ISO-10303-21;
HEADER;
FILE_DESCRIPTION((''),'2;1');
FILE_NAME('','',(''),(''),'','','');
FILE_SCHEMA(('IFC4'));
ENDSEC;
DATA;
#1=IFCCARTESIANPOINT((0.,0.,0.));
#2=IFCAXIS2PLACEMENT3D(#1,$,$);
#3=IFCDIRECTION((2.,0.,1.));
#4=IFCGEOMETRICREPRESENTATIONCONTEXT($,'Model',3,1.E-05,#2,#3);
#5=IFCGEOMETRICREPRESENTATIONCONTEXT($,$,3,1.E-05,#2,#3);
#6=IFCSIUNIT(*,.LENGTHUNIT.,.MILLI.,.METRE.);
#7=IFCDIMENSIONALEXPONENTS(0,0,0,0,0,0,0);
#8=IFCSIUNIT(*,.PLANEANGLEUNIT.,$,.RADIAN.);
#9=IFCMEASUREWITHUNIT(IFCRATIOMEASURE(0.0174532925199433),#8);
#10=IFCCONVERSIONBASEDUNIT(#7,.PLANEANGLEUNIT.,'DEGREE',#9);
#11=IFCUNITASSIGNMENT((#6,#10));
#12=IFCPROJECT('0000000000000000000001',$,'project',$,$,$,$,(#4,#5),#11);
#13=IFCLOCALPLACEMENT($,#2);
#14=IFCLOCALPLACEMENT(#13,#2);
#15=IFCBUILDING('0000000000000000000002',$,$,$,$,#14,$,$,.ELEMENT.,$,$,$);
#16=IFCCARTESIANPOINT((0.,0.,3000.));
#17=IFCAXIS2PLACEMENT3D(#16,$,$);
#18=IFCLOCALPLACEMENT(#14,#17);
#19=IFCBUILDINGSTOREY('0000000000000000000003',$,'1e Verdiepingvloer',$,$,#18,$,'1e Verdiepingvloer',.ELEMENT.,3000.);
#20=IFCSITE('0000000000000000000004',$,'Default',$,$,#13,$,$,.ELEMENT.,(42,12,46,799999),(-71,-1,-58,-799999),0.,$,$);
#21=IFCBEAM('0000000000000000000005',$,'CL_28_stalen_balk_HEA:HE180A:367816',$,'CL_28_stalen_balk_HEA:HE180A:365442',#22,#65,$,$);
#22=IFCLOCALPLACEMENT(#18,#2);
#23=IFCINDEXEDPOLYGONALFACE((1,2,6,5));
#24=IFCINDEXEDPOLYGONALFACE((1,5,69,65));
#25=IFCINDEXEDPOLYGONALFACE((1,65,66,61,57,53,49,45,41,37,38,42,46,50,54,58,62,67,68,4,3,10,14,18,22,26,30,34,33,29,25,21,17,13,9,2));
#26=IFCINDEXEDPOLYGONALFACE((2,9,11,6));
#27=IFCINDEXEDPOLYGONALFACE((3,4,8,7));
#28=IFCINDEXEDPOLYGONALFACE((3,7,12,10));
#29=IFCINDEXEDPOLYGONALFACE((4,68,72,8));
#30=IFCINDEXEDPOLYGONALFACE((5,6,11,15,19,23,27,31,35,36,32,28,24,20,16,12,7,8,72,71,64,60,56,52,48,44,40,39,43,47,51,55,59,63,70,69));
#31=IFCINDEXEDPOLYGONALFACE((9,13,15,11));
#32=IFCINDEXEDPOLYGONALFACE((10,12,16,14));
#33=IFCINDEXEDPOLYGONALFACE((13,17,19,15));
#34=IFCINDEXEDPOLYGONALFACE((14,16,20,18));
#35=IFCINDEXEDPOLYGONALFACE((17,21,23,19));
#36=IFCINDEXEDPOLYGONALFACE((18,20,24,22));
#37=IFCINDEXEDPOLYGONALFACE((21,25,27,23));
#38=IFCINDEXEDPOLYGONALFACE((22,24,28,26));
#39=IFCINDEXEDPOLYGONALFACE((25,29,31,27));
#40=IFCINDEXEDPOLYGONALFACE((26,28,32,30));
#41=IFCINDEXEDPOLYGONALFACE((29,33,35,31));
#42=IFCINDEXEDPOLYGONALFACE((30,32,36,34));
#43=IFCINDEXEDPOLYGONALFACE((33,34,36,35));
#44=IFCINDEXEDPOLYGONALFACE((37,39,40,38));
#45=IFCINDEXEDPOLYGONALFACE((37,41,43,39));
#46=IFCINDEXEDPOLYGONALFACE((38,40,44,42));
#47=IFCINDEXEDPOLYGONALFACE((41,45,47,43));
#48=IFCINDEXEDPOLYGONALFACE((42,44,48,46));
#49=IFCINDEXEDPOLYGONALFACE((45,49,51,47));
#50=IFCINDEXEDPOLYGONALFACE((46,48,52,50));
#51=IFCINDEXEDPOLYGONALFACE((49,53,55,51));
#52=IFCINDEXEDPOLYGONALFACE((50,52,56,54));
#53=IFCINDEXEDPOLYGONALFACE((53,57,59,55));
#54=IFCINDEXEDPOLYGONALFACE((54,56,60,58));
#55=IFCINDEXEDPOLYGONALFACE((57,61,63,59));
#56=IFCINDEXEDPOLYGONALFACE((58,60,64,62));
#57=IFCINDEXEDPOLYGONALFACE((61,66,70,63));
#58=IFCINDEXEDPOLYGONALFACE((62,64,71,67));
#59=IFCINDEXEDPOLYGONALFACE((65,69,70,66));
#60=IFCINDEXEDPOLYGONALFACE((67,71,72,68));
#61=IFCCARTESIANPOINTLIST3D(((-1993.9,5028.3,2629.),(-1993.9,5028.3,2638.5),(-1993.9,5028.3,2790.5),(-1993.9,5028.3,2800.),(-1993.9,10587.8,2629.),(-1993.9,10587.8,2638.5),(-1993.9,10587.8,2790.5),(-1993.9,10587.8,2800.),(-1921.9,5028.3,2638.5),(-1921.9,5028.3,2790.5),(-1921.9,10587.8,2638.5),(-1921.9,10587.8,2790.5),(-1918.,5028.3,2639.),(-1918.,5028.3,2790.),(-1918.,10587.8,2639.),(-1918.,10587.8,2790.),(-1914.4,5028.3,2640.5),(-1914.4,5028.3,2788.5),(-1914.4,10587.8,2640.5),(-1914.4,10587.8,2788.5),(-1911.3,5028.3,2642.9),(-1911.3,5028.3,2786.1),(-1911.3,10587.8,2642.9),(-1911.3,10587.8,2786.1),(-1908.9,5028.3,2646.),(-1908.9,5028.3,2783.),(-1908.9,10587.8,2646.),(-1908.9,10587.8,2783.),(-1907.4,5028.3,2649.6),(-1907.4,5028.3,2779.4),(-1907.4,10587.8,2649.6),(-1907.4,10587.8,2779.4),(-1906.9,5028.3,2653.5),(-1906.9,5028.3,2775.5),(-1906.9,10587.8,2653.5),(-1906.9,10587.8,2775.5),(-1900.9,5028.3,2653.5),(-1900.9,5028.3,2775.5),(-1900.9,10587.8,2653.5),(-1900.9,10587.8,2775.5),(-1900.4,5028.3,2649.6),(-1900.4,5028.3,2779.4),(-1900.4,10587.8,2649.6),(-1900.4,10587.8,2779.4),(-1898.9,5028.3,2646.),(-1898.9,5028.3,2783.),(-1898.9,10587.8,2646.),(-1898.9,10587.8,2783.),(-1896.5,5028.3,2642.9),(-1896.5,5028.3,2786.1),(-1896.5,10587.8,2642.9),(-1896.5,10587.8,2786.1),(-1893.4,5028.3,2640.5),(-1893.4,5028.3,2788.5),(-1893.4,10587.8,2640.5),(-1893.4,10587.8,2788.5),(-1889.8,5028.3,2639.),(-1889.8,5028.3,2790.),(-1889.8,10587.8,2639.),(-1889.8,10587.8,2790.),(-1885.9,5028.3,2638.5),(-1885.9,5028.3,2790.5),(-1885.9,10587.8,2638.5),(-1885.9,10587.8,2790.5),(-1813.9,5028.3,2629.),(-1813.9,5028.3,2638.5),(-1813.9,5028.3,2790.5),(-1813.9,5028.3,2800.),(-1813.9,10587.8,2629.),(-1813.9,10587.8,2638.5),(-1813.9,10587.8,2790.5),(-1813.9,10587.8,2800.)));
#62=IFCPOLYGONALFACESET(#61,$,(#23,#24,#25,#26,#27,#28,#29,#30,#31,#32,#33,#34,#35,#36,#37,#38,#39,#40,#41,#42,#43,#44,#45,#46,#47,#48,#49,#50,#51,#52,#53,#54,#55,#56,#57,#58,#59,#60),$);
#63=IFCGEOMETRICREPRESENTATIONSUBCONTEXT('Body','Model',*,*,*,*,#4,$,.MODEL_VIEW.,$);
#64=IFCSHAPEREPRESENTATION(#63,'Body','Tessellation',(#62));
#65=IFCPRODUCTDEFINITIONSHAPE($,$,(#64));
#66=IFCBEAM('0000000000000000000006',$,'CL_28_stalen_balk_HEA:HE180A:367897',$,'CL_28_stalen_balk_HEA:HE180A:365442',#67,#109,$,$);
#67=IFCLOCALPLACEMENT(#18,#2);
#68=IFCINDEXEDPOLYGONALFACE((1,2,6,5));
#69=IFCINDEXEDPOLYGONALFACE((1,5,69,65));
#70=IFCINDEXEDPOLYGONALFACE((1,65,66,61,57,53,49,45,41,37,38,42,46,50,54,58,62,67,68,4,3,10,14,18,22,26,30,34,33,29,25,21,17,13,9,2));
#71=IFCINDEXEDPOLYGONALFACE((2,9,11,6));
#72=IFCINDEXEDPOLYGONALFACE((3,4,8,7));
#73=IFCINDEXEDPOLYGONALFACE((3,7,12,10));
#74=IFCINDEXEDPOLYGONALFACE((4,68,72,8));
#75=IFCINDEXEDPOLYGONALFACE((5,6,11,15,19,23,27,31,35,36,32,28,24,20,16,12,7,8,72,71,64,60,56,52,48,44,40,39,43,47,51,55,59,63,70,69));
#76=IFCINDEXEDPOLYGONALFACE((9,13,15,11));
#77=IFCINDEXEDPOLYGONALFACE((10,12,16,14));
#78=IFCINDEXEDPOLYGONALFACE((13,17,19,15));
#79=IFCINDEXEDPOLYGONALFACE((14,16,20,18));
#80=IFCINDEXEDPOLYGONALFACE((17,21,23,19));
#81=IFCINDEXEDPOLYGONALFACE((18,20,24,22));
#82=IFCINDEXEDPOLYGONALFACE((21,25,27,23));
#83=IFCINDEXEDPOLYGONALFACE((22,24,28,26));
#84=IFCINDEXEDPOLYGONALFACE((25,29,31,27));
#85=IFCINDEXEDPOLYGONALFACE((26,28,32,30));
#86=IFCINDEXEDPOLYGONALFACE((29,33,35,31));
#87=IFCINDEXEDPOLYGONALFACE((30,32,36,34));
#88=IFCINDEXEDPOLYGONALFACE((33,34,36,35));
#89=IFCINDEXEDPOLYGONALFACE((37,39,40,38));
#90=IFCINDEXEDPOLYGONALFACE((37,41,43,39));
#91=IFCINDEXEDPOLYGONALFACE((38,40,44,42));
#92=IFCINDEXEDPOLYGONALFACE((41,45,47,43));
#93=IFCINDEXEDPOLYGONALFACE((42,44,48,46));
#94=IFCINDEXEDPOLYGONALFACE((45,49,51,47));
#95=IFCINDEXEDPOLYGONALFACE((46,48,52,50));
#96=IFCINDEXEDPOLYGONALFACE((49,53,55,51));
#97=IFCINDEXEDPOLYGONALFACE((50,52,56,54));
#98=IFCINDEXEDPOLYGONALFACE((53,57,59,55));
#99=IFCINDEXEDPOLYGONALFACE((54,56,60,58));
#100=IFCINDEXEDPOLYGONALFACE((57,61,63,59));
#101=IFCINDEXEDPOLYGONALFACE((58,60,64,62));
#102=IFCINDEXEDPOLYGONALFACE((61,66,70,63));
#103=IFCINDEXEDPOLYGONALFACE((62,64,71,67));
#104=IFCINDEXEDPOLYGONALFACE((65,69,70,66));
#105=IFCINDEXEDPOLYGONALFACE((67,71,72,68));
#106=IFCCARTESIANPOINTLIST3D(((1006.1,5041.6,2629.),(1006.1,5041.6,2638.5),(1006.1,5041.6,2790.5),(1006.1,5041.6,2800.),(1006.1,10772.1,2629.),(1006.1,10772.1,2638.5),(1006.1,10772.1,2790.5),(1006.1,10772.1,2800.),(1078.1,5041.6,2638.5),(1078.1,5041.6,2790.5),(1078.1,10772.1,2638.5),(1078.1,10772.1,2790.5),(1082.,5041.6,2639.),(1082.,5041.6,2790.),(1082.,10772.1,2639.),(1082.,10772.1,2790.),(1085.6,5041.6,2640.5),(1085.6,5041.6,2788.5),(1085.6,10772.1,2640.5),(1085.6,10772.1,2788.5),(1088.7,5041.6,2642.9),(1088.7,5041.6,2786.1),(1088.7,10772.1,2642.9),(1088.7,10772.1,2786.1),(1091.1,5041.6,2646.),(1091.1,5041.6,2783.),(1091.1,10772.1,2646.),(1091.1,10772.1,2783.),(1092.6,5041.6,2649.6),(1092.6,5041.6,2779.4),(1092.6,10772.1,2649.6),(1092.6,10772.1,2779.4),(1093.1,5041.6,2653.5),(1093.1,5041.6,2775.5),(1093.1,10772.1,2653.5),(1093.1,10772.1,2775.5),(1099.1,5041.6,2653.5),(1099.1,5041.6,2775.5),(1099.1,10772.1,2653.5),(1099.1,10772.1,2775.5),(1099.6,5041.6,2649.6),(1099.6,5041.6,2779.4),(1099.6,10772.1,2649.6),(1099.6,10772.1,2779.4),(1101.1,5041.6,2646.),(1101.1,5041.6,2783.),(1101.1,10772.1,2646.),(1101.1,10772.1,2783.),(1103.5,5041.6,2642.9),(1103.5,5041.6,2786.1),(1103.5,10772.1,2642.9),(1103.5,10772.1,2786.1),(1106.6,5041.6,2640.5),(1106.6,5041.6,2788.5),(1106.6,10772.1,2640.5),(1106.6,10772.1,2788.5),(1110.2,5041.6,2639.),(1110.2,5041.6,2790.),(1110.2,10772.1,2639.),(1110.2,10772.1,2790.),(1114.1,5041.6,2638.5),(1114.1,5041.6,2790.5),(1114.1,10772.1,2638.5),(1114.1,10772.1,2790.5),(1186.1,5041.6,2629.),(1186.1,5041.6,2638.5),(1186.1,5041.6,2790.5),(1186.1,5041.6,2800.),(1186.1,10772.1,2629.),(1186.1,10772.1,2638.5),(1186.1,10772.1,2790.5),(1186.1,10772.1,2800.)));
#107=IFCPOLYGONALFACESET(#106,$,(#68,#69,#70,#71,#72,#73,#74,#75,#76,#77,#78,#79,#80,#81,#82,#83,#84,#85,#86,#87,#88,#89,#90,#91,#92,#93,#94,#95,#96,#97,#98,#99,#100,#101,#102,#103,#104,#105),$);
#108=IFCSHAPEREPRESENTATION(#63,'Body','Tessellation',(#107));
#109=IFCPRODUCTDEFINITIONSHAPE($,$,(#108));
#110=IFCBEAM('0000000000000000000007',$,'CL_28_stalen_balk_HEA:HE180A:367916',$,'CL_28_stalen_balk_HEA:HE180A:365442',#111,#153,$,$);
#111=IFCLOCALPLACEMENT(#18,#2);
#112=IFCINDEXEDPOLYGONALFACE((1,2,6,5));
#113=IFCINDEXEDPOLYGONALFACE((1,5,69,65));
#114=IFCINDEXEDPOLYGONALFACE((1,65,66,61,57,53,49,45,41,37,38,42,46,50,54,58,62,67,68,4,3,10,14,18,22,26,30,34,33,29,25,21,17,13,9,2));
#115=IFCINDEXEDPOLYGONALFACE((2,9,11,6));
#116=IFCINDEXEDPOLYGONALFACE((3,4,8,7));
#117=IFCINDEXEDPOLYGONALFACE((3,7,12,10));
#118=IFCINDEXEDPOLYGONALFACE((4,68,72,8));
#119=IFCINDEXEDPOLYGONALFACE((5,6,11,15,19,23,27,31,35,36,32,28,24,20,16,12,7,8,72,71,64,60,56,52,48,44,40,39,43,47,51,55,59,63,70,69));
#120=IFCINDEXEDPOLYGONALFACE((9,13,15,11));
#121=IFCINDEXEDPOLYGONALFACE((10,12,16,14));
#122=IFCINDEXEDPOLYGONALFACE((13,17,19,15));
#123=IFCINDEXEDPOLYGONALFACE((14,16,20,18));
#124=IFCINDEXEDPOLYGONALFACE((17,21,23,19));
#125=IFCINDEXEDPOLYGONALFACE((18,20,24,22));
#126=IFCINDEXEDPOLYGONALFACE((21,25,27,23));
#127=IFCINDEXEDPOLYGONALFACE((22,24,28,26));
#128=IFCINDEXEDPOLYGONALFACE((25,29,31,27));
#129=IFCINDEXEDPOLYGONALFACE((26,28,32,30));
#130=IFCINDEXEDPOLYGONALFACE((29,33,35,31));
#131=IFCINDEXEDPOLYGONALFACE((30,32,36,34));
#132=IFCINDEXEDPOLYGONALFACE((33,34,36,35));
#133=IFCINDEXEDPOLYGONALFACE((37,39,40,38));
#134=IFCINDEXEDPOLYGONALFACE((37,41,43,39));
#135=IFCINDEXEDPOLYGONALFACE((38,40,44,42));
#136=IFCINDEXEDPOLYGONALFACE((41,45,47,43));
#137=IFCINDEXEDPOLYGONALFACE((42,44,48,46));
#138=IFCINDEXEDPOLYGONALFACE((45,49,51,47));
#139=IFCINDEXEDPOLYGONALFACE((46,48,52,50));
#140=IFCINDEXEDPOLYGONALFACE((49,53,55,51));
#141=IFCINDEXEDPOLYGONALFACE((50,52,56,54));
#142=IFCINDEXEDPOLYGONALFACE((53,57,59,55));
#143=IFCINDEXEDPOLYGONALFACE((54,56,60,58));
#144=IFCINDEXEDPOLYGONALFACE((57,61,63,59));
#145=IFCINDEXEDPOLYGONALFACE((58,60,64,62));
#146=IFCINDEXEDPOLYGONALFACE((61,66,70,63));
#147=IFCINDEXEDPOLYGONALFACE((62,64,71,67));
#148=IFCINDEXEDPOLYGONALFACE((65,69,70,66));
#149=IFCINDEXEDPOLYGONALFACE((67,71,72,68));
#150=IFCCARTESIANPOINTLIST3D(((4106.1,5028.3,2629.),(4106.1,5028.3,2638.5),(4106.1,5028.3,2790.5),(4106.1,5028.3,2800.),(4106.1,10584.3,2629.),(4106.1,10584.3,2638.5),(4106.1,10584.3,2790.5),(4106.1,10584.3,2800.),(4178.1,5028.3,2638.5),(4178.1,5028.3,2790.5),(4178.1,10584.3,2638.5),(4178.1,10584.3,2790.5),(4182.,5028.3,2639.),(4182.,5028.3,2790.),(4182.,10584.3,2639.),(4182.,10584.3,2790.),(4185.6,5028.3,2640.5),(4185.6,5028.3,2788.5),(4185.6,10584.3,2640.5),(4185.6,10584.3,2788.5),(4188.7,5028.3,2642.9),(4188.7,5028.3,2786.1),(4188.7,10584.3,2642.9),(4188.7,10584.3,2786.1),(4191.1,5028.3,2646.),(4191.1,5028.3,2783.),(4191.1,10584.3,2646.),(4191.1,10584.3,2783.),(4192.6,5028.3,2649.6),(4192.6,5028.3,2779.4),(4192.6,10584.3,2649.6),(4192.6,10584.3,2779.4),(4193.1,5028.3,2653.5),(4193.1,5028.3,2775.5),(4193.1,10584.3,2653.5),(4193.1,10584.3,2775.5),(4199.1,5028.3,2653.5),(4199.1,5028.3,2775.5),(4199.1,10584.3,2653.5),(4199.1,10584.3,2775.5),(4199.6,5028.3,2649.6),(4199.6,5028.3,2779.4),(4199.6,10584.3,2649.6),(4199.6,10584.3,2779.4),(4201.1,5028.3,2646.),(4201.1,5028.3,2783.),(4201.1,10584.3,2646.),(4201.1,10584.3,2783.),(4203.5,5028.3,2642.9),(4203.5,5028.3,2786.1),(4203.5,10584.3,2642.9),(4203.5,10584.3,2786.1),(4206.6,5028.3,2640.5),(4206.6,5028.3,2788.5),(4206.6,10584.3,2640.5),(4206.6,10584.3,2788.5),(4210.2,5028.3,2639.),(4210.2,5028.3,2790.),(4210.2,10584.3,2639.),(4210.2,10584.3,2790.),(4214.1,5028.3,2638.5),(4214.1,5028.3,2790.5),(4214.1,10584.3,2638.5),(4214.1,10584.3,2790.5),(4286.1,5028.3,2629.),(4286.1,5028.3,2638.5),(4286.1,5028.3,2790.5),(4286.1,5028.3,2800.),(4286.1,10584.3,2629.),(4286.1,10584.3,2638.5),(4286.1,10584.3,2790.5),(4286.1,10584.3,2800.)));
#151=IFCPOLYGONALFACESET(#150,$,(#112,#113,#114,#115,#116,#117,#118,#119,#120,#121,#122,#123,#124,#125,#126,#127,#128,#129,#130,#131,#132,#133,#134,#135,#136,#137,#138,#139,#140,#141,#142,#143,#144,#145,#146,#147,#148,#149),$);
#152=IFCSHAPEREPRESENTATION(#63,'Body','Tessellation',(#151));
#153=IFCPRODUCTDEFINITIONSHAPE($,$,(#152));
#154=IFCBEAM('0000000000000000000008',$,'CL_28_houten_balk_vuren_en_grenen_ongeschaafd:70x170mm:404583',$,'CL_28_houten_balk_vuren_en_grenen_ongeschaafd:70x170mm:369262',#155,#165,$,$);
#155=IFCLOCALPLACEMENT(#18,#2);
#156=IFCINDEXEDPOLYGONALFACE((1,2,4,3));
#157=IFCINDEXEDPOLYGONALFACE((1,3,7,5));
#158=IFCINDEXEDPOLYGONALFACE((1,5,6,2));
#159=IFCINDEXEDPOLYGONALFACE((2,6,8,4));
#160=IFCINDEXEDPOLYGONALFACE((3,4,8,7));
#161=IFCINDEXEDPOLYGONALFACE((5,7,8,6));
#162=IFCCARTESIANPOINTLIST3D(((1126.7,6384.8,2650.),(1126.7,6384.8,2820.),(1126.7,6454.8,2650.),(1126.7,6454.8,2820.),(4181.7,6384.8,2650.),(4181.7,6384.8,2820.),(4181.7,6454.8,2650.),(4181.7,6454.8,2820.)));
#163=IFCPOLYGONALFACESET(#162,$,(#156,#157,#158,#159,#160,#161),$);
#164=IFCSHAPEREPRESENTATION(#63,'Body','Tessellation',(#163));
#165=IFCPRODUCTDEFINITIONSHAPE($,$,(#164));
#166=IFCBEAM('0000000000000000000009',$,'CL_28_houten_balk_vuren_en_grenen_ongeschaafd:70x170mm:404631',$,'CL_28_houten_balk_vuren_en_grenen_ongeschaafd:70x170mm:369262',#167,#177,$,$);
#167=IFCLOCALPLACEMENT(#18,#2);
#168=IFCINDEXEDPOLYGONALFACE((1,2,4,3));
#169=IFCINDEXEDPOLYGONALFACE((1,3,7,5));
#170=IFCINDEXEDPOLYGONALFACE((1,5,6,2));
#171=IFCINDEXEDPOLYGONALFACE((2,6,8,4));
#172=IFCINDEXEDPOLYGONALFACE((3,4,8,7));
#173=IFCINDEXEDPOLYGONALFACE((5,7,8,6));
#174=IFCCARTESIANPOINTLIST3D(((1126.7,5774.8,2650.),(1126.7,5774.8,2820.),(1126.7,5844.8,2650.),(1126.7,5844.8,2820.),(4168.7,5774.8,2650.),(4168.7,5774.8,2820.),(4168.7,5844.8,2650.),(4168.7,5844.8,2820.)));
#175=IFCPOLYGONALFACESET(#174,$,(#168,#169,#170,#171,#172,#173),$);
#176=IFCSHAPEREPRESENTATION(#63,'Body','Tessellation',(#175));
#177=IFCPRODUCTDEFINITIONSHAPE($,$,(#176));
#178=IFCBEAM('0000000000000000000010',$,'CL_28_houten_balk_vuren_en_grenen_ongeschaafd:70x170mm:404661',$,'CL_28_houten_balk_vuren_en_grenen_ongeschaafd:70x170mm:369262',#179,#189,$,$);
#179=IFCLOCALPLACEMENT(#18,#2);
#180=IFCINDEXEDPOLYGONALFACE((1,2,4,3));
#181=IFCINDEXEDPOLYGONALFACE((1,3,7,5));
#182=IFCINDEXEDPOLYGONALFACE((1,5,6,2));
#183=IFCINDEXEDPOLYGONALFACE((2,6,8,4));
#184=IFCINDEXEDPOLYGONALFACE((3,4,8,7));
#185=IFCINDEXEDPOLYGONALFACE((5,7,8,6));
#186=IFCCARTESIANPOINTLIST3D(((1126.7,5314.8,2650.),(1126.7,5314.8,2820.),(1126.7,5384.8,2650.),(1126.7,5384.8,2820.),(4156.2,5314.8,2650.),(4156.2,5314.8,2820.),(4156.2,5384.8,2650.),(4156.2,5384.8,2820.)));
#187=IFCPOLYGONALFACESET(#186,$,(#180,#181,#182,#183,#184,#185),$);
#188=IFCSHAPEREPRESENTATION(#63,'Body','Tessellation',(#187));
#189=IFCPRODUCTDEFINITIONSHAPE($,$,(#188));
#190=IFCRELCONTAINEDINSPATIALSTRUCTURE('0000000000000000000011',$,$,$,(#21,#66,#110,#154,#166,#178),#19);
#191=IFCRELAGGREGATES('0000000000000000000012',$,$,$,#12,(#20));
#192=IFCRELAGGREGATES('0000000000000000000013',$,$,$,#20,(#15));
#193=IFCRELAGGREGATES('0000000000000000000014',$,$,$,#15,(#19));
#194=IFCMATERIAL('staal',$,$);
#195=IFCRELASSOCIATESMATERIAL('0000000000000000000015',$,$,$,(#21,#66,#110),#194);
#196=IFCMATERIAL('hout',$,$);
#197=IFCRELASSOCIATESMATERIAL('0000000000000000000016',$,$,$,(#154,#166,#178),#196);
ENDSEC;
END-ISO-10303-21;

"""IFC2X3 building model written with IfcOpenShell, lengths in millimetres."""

from ifc_helpers import new_model, entity, si_unit, converted_unit, direction, frame, frame_2d, origin, place, context, subcontext, project, spatial, rectangle, i_section, extrude, material, element, save


model = new_model("IFC2X3")

# Units and contexts
model_context = context("Model", 3, precision=1e-05, world=origin(), true_north=direction((2.0, 0.0, 1.0)))
context_of_model = context(None, 3, precision=1e-05, world=origin(), true_north=direction((2.0, 0.0, 1.0)))
body_context = subcontext(model_context, "Body", "Model", "MODEL_VIEW")
ifc_project = project(units=[si_unit("LENGTHUNIT", "METRE", prefix="MILLI"), converted_unit("PLANEANGLEUNIT", "DEGREE", entity("IfcRatioMeasure", 0.0174532925199433), si_unit("PLANEANGLEUNIT", "RADIAN"), dimensions=[0, 0, 0, 0, 0, 0, 0])], contexts=[model_context, context_of_model])

# Site, building, storey
site_placement = place(None, origin())
site = spatial("IfcSite", under=ifc_project, at=site_placement, Name="Default", CompositionType="ELEMENT", RefLatitude=(42, 12, 46, 799999), RefLongitude=(-71, -1, -58, -799999), RefElevation=0.0)
building_placement = place(site_placement, origin())
building = spatial("IfcBuilding", under=site, at=building_placement, CompositionType="ELEMENT")
storey_placement = place(building_placement, frame((0.0, 0.0, 3000.0)))
storey = spatial("IfcBuildingStorey", under=building, at=storey_placement, Name="1e Verdiepingvloer", LongName="1e Verdiepingvloer", CompositionType="ELEMENT", Elevation=3000.0)

# Beams
ifc_material_1 = material(Name="staal")
beam_1_placement = place(storey_placement, frame((-1903.9, 4959.8, 2800.0), z_axis=(0.0, 0.0, 1.0), x_axis=(0.0, 1.0, 0.0)))
element("IfcBeam", 1, at=beam_1_placement, inside=storey, material=ifc_material_1, Name="CL_28_stalen_balk_HEA:HE180A:367816", ObjectType="CL_28_stalen_balk_HEA:HE180A:365442", context=body_context, shape_type="SweptSolid", body=[
    extrude(i_section(OverallWidth=180.0, OverallDepth=171.0, WebThickness=6.0, FlangeThickness=9.5, FilletRadius=15.0, at=frame_2d((0.0, 0.0), x_axis=(0.0, 1.0))), frame((68.5, 0.0, -85.5), z_axis=(1.0, 0.0, 0.0), x_axis=(0.0, 0.0, -1.0)), (0.0, 0.0, 1.0), 5559.5),
])
beam_2_placement = place(storey_placement, frame((1096.1, 4916.8, 2800.0), z_axis=(0.0, 0.0, 1.0), x_axis=(0.0, 1.0, 0.0)))
element("IfcBeam", 2, at=beam_2_placement, inside=storey, material=ifc_material_1, Name="CL_28_stalen_balk_HEA:HE180A:367897", ObjectType="CL_28_stalen_balk_HEA:HE180A:365442", context=body_context, shape_type="SweptSolid", body=[
    extrude(i_section(OverallWidth=180.0, OverallDepth=171.0, WebThickness=6.0, FlangeThickness=9.5, FilletRadius=15.0, at=frame_2d((0.0, 0.0), x_axis=(0.0, 1.0))), frame((124.8, 0.0, -85.5), z_axis=(1.0, 0.0, 0.0), x_axis=(0.0, 0.0, -1.0)), (0.0, 0.0, 1.0), 5730.5),
])
beam_3_placement = place(storey_placement, frame((4196.1, 4959.8, 2800.0), z_axis=(0.0, 0.0, 1.0), x_axis=(0.0, 1.0, 0.0)))
element("IfcBeam", 3, at=beam_3_placement, inside=storey, material=ifc_material_1, Name="CL_28_stalen_balk_HEA:HE180A:367916", ObjectType="CL_28_stalen_balk_HEA:HE180A:365442", context=body_context, shape_type="SweptSolid", body=[
    extrude(i_section(OverallWidth=180.0, OverallDepth=171.0, WebThickness=6.0, FlangeThickness=9.5, FilletRadius=15.0, at=frame_2d((0.0, 0.0), x_axis=(0.0, 1.0))), frame((68.5, 0.0, -85.5), z_axis=(1.0, 0.0, 0.0), x_axis=(0.0, 0.0, -1.0)), (0.0, 0.0, 1.0), 5555.9),
])
ifc_material_2 = material(Name="hout")
beam_4_placement = place(storey_placement, frame((971.1, 6419.8, 2820.0)))
element("IfcBeam", 4, at=beam_4_placement, inside=storey, material=ifc_material_2, Name="CL_28_houten_balk_vuren_en_grenen_ongeschaafd:70x170mm:404583", ObjectType="CL_28_houten_balk_vuren_en_grenen_ongeschaafd:70x170mm:369262", context=body_context, shape_type="SweptSolid", body=[
    extrude(rectangle(XDim=170.0, YDim=70.0, at=frame_2d((0.0, 0.0), x_axis=(1.0, 0.0))), frame((155.6, 0.0, -85.0), z_axis=(1.0, 0.0, 0.0), x_axis=(0.0, 0.0, -1.0)), (0.0, 0.0, 1.0), 3055.0),
])
beam_5_placement = place(storey_placement, frame((971.1, 5809.8, 2820.0)))
element("IfcBeam", 5, at=beam_5_placement, inside=storey, material=ifc_material_2, Name="CL_28_houten_balk_vuren_en_grenen_ongeschaafd:70x170mm:404631", ObjectType="CL_28_houten_balk_vuren_en_grenen_ongeschaafd:70x170mm:369262", context=body_context, shape_type="SweptSolid", body=[
    extrude(rectangle(XDim=170.0, YDim=70.0, at=frame_2d((0.0, 0.0), x_axis=(1.0, 0.0))), frame((155.6, 0.0, -85.0), z_axis=(1.0, 0.0, 0.0), x_axis=(0.0, 0.0, -1.0)), (0.0, 0.0, 1.0), 3042.0),
])
beam_6_placement = place(storey_placement, frame((971.1, 5349.8, 2820.0)))
element("IfcBeam", 6, at=beam_6_placement, inside=storey, material=ifc_material_2, Name="CL_28_houten_balk_vuren_en_grenen_ongeschaafd:70x170mm:404661", ObjectType="CL_28_houten_balk_vuren_en_grenen_ongeschaafd:70x170mm:369262", context=body_context, shape_type="SweptSolid", body=[
    extrude(rectangle(XDim=170.0, YDim=70.0, at=frame_2d((0.0, 0.0), x_axis=(1.0, 0.0))), frame((155.6, 0.0, -85.0), z_axis=(1.0, 0.0, 0.0), x_axis=(0.0, 0.0, -1.0)), (0.0, 0.0, 1.0), 3029.5),
])

save(model, "model.ifc")
